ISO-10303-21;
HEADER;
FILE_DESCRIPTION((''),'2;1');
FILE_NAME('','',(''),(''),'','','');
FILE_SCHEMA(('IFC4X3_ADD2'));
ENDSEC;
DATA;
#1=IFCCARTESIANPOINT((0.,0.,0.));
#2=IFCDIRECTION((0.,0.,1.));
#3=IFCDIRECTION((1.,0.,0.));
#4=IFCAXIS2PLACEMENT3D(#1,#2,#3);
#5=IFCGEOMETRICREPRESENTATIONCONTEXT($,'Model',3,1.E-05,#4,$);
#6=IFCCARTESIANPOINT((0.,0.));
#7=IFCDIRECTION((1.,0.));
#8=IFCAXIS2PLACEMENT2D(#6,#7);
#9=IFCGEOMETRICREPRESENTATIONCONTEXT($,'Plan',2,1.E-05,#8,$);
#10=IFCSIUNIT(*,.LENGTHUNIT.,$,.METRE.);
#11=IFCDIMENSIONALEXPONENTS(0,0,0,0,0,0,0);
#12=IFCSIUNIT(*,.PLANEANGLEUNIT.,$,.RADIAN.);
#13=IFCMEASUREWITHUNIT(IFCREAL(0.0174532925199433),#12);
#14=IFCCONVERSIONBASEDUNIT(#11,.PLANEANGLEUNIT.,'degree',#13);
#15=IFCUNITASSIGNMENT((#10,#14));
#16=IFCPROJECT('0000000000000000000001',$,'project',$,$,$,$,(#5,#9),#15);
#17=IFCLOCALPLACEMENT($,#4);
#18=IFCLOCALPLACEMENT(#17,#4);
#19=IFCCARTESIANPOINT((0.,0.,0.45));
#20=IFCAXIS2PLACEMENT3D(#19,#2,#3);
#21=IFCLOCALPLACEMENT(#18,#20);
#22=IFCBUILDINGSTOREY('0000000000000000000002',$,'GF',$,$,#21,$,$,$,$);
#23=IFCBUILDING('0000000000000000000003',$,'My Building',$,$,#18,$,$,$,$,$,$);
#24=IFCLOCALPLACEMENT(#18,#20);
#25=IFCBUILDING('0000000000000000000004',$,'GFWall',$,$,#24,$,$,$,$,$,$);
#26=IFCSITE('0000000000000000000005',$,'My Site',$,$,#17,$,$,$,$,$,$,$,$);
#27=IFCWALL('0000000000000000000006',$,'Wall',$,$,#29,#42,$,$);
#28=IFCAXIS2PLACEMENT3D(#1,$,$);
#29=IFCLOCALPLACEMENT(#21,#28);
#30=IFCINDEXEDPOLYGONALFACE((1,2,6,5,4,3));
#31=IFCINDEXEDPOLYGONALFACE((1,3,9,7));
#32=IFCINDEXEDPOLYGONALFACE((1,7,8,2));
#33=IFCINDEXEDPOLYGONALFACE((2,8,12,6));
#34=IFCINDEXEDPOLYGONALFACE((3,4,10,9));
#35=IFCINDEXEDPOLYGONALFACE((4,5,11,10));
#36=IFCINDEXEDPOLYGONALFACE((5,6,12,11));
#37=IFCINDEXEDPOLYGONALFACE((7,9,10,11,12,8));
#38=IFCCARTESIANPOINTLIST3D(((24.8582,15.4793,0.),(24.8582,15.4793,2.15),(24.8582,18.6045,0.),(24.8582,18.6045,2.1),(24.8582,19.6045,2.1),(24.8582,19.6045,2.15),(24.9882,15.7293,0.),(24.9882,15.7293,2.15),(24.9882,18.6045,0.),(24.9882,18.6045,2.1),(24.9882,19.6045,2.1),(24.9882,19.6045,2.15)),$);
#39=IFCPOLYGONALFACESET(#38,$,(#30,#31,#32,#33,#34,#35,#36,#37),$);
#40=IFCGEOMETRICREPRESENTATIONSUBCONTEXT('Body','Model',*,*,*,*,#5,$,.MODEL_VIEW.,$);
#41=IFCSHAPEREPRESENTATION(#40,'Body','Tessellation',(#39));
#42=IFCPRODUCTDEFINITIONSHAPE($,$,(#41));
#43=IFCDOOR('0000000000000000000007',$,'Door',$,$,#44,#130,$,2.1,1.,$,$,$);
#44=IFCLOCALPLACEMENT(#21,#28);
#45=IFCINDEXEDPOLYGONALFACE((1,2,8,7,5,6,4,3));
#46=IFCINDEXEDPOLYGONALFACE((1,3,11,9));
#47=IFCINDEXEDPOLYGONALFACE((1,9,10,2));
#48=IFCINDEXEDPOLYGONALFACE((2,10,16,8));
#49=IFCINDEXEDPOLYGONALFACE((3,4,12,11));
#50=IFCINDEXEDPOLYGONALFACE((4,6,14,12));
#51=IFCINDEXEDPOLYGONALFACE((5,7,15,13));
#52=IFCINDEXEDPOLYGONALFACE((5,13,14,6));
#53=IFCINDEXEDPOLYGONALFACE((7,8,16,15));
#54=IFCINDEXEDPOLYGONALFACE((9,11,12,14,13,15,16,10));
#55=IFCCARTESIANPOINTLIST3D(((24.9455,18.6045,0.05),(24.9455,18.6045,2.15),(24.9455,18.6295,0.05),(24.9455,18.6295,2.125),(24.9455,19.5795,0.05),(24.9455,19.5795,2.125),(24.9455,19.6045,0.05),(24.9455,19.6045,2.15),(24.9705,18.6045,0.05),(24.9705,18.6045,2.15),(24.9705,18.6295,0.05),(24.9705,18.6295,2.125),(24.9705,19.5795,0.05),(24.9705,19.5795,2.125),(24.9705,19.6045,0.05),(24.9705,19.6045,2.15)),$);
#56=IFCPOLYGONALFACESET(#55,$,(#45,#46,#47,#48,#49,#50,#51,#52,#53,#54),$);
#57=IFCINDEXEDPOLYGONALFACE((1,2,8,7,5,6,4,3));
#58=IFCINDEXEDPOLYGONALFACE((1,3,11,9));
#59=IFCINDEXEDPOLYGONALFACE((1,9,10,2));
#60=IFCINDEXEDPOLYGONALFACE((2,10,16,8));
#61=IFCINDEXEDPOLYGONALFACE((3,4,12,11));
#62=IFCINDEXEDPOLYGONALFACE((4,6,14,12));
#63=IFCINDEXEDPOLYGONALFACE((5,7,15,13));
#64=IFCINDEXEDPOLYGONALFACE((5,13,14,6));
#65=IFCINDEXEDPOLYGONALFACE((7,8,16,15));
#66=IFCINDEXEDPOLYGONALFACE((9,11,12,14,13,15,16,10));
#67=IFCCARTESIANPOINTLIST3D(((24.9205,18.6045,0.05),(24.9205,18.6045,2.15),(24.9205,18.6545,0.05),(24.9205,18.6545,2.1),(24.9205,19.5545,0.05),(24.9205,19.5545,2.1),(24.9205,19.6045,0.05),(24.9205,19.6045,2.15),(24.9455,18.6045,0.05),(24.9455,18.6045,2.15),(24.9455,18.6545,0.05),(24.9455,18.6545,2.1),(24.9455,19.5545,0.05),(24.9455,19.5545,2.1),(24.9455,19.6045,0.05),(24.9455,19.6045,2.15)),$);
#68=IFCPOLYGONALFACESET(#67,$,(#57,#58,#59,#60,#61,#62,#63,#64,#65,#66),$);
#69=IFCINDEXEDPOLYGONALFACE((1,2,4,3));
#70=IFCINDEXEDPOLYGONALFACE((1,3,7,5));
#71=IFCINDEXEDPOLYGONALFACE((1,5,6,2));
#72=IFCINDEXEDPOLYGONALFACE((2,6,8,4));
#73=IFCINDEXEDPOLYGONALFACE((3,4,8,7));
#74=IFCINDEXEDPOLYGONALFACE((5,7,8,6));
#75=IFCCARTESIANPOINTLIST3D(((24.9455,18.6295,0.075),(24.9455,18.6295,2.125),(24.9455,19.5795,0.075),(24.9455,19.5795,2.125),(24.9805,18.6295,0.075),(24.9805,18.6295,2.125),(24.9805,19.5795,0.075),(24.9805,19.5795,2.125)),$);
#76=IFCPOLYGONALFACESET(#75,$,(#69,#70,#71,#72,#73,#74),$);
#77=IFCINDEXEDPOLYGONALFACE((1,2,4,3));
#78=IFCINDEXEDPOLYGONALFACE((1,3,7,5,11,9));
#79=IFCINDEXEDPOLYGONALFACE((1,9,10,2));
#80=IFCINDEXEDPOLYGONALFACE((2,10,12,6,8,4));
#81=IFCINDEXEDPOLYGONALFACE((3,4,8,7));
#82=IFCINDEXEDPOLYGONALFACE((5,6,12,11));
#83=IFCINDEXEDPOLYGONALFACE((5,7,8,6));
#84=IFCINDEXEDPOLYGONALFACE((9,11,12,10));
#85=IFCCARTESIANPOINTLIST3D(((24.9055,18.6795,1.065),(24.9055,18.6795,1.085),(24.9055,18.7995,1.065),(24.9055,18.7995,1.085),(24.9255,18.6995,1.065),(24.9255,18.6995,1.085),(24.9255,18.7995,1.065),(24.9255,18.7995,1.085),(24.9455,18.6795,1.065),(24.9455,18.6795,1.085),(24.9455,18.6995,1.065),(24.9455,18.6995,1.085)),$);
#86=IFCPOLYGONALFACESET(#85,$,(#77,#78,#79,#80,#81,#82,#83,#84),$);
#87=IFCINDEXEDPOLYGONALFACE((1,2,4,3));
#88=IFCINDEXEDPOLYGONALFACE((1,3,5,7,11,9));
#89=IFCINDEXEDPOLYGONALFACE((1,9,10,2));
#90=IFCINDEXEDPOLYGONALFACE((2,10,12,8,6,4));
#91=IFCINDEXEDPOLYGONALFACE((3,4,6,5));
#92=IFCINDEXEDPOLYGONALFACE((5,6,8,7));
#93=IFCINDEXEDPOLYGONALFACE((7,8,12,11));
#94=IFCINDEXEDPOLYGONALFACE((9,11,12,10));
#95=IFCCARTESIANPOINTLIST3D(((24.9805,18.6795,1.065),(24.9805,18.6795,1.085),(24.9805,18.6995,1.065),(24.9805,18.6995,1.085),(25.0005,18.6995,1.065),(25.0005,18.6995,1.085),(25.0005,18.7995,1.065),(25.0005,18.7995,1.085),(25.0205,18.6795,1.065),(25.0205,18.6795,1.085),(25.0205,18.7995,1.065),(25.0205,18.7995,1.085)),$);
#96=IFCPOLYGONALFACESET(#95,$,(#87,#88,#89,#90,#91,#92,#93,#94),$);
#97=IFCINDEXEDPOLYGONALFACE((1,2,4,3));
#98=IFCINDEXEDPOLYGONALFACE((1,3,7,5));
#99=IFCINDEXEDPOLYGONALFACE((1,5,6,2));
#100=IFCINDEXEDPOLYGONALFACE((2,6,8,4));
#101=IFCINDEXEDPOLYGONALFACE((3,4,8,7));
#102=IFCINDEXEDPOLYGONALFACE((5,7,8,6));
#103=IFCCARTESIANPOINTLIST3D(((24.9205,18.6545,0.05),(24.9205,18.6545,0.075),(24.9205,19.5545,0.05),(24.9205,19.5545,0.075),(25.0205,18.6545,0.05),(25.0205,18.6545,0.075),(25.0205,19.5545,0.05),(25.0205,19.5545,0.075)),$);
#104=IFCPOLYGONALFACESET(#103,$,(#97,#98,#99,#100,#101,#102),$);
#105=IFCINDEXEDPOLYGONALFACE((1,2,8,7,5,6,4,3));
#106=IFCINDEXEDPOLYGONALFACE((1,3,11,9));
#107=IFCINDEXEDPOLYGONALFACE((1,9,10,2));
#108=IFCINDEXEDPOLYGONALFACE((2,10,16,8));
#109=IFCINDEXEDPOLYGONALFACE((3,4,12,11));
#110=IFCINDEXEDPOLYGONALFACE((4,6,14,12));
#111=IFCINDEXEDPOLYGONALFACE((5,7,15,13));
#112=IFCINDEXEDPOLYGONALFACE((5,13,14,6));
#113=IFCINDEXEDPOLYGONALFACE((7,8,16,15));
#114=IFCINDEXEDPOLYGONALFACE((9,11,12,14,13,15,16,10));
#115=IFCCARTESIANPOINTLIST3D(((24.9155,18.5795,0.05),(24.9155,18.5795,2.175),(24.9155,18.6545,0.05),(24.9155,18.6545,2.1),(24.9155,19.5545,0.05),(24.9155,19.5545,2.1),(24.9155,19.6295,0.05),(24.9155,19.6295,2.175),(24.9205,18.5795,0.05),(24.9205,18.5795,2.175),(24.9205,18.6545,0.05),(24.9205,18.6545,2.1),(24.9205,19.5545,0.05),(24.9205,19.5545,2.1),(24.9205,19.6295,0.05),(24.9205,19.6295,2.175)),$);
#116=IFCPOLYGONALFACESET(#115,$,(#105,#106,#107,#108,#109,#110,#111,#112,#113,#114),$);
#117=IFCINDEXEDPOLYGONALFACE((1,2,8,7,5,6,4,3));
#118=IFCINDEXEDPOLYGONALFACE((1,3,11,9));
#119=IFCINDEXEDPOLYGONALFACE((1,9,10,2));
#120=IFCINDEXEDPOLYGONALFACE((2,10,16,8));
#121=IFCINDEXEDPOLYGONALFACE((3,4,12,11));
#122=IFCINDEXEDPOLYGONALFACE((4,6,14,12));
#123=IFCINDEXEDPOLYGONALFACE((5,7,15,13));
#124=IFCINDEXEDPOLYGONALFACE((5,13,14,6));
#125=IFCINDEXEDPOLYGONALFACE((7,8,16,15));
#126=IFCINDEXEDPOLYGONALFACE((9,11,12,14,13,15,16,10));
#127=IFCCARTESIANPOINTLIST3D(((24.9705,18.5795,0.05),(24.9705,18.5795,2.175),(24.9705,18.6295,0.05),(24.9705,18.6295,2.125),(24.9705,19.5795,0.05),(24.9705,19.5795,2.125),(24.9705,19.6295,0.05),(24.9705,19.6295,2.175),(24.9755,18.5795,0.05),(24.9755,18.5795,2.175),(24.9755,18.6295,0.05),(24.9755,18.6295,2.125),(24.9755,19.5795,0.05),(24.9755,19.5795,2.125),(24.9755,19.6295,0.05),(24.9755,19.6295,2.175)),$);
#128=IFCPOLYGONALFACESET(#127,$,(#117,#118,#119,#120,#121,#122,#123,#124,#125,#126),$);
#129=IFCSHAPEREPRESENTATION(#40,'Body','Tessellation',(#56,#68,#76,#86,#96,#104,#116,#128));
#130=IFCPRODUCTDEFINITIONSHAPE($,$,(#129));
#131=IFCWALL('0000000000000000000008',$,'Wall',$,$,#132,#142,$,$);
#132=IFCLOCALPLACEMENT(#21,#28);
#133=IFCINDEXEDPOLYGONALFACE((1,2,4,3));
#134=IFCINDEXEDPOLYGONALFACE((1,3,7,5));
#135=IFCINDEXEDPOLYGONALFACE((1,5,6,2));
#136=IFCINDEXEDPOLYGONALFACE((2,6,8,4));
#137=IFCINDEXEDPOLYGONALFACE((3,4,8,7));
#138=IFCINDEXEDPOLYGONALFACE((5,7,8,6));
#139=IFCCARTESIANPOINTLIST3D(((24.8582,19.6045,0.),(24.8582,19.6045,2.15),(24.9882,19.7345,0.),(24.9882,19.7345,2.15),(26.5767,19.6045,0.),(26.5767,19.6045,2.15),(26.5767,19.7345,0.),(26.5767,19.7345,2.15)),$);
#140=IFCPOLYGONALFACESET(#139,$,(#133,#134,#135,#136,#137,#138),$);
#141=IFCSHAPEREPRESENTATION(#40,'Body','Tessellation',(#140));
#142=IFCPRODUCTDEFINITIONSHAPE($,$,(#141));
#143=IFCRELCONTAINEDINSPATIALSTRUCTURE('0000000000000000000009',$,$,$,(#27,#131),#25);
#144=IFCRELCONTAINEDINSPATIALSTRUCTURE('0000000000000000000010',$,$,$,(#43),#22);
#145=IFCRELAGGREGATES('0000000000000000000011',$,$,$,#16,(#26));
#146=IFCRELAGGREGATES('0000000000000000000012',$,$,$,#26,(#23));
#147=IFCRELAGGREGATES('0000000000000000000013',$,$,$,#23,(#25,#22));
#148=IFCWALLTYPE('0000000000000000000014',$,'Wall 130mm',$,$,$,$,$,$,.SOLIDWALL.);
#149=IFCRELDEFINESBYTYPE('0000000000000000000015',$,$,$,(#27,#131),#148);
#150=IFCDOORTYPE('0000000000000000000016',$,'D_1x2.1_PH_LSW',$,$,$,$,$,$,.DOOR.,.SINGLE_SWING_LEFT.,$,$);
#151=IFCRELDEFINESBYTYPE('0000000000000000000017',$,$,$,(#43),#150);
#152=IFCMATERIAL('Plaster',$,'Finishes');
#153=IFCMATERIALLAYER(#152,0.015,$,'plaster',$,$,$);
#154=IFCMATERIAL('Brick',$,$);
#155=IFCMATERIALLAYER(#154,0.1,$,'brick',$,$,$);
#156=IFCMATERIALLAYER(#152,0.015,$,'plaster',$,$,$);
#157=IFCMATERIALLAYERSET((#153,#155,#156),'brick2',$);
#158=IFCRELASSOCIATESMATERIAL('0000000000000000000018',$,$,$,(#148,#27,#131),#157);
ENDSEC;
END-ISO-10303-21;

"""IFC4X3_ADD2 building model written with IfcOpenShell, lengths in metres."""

from ifc_helpers import new_model, entity, si_unit, converted_unit, frame, origin_with_axes, origin_2d_with_axis, place, context, subcontext, project, spatial, line, indexed_curve, outline, extrude, shape, source, transform, mapped, material, layer, layer_set, layer_usage, type_object, type_shapes, element, fill, save


model = new_model("IFC4X3_ADD2")

# Units and contexts
model_context = context("Model", 3, precision=1e-05, world=origin_with_axes())
plan_context = context("Plan", 2, precision=1e-05, world=origin_2d_with_axis())
body_context_1 = subcontext(model_context, "Body", "Model", "MODEL_VIEW")
body_context_2 = subcontext(plan_context, "Body", "Plan", "PLAN_VIEW")
ifc_project = project(units=[si_unit("LENGTHUNIT", "METRE"), converted_unit("PLANEANGLEUNIT", "degree", entity("IfcReal", 0.0174532925199433), si_unit("PLANEANGLEUNIT", "RADIAN"), dimensions=[0, 0, 0, 0, 0, 0, 0])], contexts=[model_context, plan_context])

# Site, buildings
site_placement = place(None, origin_with_axes())
site = spatial("IfcSite", under=ifc_project, at=site_placement, Name="My Site")
building_1_placement = place(site_placement, origin_with_axes())
building_1 = spatial("IfcBuilding", under=site, at=building_1_placement, Name="My Building")
building_2_placement = place(building_1_placement, frame((0.0, 0.0, 0.45), z_axis=(0.0, 0.0, 1.0), x_axis=(1.0, 0.0, 0.0)))
building_2 = spatial("IfcBuilding", under=building_1, at=building_2_placement, Name="GFWall")

# Shared definitions
storey_placement = place(building_1_placement, frame((0.0, 0.0, 0.45), z_axis=(0.0, 0.0, 1.0), x_axis=(1.0, 0.0, 0.0)))
storey = spatial("IfcBuildingStorey", under=building_1, at=storey_placement, Name="GF")

# Wall, opening, door
ifc_material_1 = material(Name="Plaster", Category="Finishes")
ifc_layer_1 = layer(ifc_material_1, 0.015, Name="plaster")
ifc_material_2 = material(Name="Brick")
ifc_layer_2 = layer(ifc_material_2, 0.1, Name="brick")
ifc_layer_3 = layer(ifc_material_1, 0.015, Name="plaster")
ifc_layer_set_1 = layer_set([ifc_layer_1, ifc_layer_2, ifc_layer_3], Name="brick2")
ifc_layer_usage_1 = layer_usage(ifc_layer_set_1, "AXIS2", "POSITIVE", 0.0)
wall_type_1 = type_object("IfcWallType", Name="Wall 130mm", PredefinedType="SOLIDWALL", material=ifc_layer_set_1)
wall_1_placement = place(building_2_placement, frame((24.9882, 15.4793, 0.0), z_axis=(0.0, 0.0, 1.0), x_axis=(0.0, 1.0, 0.0)))
wall_1 = element("IfcWall", 1, at=wall_1_placement, inside=building_2, type_object=wall_type_1, material=ifc_layer_usage_1, Name="Wall", context=body_context_1, shape_type="SweptSolid", body=[
    extrude(outline(indexed_curve([(0.25, 0.0), (0.0, 0.13), (4.1252, 0.13), (4.1252, 0.0)], segments=[line(1, 2, 3, 4, 1)])), origin_with_axes(), (0.0, 0.0, 1.0), 2.15),
])
shared_shape_1 = source(origin_with_axes(), body_context_1, "Body", "SweptSolid", [
    extrude(outline(indexed_curve([(0.0, 0.0), (1.0, 0.0), (1.0, 2.1), (0.0, 2.1)], segments=[line(1, 2, 3, 4, 1)])), frame((0.0, -0.6, 0.0), z_axis=(0.0, -1.0, 0.0), x_axis=(1.0, 0.0, 0.0)), (0.0, 0.0, -1.0), 1.2),
])
opening_1_placement = place(wall_1_placement, frame((4.1252, 0.0527, 0.0), z_axis=(0.0, 0.0, 1.0), x_axis=(-1.0, 0.0, 0.0)))
opening_1 = element("IfcOpeningElement", 2, at=opening_1_placement, cuts=wall_1, PredefinedType="OPENING", context=body_context_1, shape_type="MappedRepresentation", body=[
    mapped(shared_shape_1, transform((0.0, 0.0, 0.0), x_axis=(1.0, 0.0, 0.0), y_axis=(0.0, 1.0, 0.0), z_axis=(0.0, 0.0, 1.0), scale=1.0)),
])
door_type_1 = type_object("IfcDoorType", Name="D_1x2.1_PH_LSW", OperationType="SINGLE_SWING_LEFT", PredefinedType="DOOR")
shared_shape_2 = source(origin_with_axes(), body_context_1, "Body", "SweptSolid", [
    extrude(outline(indexed_curve([(0.0, 0.0), (0.0, 2.1), (1.0, 2.1), (1.0, 0.0), (0.975, 0.0), (0.975, 2.075), (0.025, 2.075), (0.025, 0.0)], segments=[line(1, 2, 3, 4, 5, 6, 7, 8, 1)])), frame((0.0, 0.025, 0.0), z_axis=(0.0, -1.0, 0.0), x_axis=(1.0, 0.0, 0.0)), (0.0, 0.0, -1.0), 0.025),
    extrude(outline(indexed_curve([(0.0, 0.0), (0.0, 2.1), (1.0, 2.1), (1.0, 0.0), (0.95, 0.0), (0.95, 2.05), (0.05, 2.05), (0.05, 0.0)], segments=[line(1, 2, 3, 4, 5, 6, 7, 8, 1)])), frame((0.0, 0.0, 0.0), z_axis=(0.0, -1.0, 0.0), x_axis=(1.0, 0.0, 0.0)), (0.0, 0.0, -1.0), 0.025),
    extrude(outline(indexed_curve([(0.0, 0.0), (0.95, 0.0), (0.95, 0.035), (0.0, 0.035)], segments=[line(1, 2, 3, 4, 1)])), frame((0.025, 0.025, 0.025), z_axis=(0.0, 0.0, 1.0), x_axis=(1.0, 0.0, 0.0)), (0.0, 0.0, 1.0), 2.05),
    extrude(outline(indexed_curve([(0.0, 0.0), (0.0, -0.04), (-0.12, -0.04), (-0.12, -0.02), (-0.02, -0.02), (-0.02, 0.0)], segments=[line(1, 2, 3, 4, 5, 6, 1)])), frame((0.925, 0.025, 1.015), z_axis=(0.0, 0.0, 1.0), x_axis=(1.0, 0.0, 0.0)), (0.0, 0.0, 1.0), 0.02),
    extrude(outline(indexed_curve([(0.0, 0.0), (0.0, 0.04), (-0.12, 0.04), (-0.12, 0.02), (-0.02, 0.02), (-0.02, 0.0)], segments=[line(1, 2, 3, 4, 5, 6, 1)])), frame((0.925, 0.06, 1.015), z_axis=(0.0, 0.0, 1.0), x_axis=(1.0, 0.0, 0.0)), (0.0, 0.0, 1.0), 0.02),
    extrude(outline(indexed_curve([(0.0, 0.0), (0.9, 0.0), (0.9, 0.1), (0.0, 0.1)], segments=[line(1, 2, 3, 4, 1)])), frame((0.05, 0.0, 0.0), z_axis=(0.0, 0.0, 1.0), x_axis=(1.0, 0.0, 0.0)), (0.0, 0.0, 1.0), 0.025),
    extrude(outline(indexed_curve([(0.0, 0.0), (0.0, 2.125), (1.05, 2.125), (1.05, 0.0), (0.975, 0.0), (0.975, 2.05), (0.075, 2.05), (0.075, 0.0)], segments=[line(1, 2, 3, 4, 5, 6, 7, 8, 1)])), frame((-0.025, -0.005, 0.0), z_axis=(0.0, -1.0, 0.0), x_axis=(1.0, 0.0, 0.0)), (0.0, 0.0, -1.0), 0.005),
    extrude(outline(indexed_curve([(0.0, 0.0), (0.0, 2.125), (1.05, 2.125), (1.05, 0.0), (1.0, 0.0), (1.0, 2.075), (0.05, 2.075), (0.05, 0.0)], segments=[line(1, 2, 3, 4, 5, 6, 7, 8, 1)])), frame((-0.025, 0.05, 0.0), z_axis=(0.0, -1.0, 0.0), x_axis=(1.0, 0.0, 0.0)), (0.0, 0.0, -1.0), 0.005),
])
shared_shape_3 = source(origin_with_axes(), body_context_2, "Body", "Curve2D", [
    entity("IfcIndexedPolyCurve", entity("IfcCartesianPointList2D", [[0.0, 0.0], [0.0, 0.05], [0.025, 0.05], [0.025, 0.025], [0.05, 0.025], [0.05, 0.0]]), [entity("IfcLineIndex", [1, 2, 3, 4, 5, 6, 1])]),
    entity("IfcIndexedPolyCurve", entity("IfcCartesianPointList2D", [[1.0, 0.0], [1.0, 0.05], [0.975, 0.05], [0.975, 0.025], [0.95, 0.025], [0.95, 0.0]]), [entity("IfcLineIndex", [1, 2, 3, 4, 5, 6, 1])]),
    entity("IfcTrimmedCurve", entity("IfcEllipse", entity("IfcAxis2Placement2D", entity("IfcCartesianPoint", [0.06, 0.05]), entity("IfcDirection", [1.0, 0.0])), 0.915, 0.95), [entity("IfcCartesianPoint", [0.975, 0.05])], [entity("IfcCartesianPoint", [0.06, 1.0])], True, "CARTESIAN"),
    entity("IfcIndexedPolyCurve", entity("IfcCartesianPointList2D", [[0.025, 0.05], [0.06, 0.05], [0.06, 1.0], [0.025, 1.0]]), [entity("IfcLineIndex", [1, 2, 3, 4, 1])]),
])
type_shapes(door_type_1, [shared_shape_2, shared_shape_3])
door_1_placement = place(opening_1_placement, frame((0.0, -0.015, 0.05), z_axis=(0.0, 0.0, 1.0), x_axis=(1.0, 0.0, 0.0)))
door_1 = element("IfcDoor", 3, at=door_1_placement, inside=storey, type_object=door_type_1, Name="Door", OverallHeight=2.1, OverallWidth=1.0, shapes=[
    shape(body_context_1, "Body", "MappedRepresentation", [mapped(shared_shape_2, transform((0.0, 0.0, 0.0), x_axis=(1.0, 0.0, 0.0), y_axis=(0.0, 1.0, 0.0), z_axis=(0.0, 0.0, 1.0), scale=1.0))]),
    shape(body_context_2, "Body", "MappedRepresentation", [mapped(shared_shape_3, transform((0.0, 0.0, 0.0), x_axis=(1.0, 0.0, 0.0), y_axis=(0.0, 1.0, 0.0), z_axis=(0.0, 0.0, 1.0), scale=1.0))]),
])
fill(opening_1, door_1)

# Wall
ifc_layer_usage_2 = layer_usage(ifc_layer_set_1, "AXIS2", "POSITIVE", 0.0)
wall_2_placement = place(building_2_placement, frame((24.9882, 19.6045, 0.0), z_axis=(0.0, 0.0, 1.0), x_axis=(1.0, 0.0, 0.0)))
element("IfcWall", 4, at=wall_2_placement, inside=building_2, type_object=wall_type_1, material=ifc_layer_usage_2, Name="Wall", context=body_context_1, shape_type="SweptSolid", body=[
    extrude(outline(indexed_curve([(-0.13, 0.0), (0.0, 0.13), (1.5885, 0.13), (1.5885, 0.0)], segments=[line(1, 2, 3, 4, 1)])), origin_with_axes(), (0.0, 0.0, 1.0), 2.15),
])

save(model, "model.ifc")
